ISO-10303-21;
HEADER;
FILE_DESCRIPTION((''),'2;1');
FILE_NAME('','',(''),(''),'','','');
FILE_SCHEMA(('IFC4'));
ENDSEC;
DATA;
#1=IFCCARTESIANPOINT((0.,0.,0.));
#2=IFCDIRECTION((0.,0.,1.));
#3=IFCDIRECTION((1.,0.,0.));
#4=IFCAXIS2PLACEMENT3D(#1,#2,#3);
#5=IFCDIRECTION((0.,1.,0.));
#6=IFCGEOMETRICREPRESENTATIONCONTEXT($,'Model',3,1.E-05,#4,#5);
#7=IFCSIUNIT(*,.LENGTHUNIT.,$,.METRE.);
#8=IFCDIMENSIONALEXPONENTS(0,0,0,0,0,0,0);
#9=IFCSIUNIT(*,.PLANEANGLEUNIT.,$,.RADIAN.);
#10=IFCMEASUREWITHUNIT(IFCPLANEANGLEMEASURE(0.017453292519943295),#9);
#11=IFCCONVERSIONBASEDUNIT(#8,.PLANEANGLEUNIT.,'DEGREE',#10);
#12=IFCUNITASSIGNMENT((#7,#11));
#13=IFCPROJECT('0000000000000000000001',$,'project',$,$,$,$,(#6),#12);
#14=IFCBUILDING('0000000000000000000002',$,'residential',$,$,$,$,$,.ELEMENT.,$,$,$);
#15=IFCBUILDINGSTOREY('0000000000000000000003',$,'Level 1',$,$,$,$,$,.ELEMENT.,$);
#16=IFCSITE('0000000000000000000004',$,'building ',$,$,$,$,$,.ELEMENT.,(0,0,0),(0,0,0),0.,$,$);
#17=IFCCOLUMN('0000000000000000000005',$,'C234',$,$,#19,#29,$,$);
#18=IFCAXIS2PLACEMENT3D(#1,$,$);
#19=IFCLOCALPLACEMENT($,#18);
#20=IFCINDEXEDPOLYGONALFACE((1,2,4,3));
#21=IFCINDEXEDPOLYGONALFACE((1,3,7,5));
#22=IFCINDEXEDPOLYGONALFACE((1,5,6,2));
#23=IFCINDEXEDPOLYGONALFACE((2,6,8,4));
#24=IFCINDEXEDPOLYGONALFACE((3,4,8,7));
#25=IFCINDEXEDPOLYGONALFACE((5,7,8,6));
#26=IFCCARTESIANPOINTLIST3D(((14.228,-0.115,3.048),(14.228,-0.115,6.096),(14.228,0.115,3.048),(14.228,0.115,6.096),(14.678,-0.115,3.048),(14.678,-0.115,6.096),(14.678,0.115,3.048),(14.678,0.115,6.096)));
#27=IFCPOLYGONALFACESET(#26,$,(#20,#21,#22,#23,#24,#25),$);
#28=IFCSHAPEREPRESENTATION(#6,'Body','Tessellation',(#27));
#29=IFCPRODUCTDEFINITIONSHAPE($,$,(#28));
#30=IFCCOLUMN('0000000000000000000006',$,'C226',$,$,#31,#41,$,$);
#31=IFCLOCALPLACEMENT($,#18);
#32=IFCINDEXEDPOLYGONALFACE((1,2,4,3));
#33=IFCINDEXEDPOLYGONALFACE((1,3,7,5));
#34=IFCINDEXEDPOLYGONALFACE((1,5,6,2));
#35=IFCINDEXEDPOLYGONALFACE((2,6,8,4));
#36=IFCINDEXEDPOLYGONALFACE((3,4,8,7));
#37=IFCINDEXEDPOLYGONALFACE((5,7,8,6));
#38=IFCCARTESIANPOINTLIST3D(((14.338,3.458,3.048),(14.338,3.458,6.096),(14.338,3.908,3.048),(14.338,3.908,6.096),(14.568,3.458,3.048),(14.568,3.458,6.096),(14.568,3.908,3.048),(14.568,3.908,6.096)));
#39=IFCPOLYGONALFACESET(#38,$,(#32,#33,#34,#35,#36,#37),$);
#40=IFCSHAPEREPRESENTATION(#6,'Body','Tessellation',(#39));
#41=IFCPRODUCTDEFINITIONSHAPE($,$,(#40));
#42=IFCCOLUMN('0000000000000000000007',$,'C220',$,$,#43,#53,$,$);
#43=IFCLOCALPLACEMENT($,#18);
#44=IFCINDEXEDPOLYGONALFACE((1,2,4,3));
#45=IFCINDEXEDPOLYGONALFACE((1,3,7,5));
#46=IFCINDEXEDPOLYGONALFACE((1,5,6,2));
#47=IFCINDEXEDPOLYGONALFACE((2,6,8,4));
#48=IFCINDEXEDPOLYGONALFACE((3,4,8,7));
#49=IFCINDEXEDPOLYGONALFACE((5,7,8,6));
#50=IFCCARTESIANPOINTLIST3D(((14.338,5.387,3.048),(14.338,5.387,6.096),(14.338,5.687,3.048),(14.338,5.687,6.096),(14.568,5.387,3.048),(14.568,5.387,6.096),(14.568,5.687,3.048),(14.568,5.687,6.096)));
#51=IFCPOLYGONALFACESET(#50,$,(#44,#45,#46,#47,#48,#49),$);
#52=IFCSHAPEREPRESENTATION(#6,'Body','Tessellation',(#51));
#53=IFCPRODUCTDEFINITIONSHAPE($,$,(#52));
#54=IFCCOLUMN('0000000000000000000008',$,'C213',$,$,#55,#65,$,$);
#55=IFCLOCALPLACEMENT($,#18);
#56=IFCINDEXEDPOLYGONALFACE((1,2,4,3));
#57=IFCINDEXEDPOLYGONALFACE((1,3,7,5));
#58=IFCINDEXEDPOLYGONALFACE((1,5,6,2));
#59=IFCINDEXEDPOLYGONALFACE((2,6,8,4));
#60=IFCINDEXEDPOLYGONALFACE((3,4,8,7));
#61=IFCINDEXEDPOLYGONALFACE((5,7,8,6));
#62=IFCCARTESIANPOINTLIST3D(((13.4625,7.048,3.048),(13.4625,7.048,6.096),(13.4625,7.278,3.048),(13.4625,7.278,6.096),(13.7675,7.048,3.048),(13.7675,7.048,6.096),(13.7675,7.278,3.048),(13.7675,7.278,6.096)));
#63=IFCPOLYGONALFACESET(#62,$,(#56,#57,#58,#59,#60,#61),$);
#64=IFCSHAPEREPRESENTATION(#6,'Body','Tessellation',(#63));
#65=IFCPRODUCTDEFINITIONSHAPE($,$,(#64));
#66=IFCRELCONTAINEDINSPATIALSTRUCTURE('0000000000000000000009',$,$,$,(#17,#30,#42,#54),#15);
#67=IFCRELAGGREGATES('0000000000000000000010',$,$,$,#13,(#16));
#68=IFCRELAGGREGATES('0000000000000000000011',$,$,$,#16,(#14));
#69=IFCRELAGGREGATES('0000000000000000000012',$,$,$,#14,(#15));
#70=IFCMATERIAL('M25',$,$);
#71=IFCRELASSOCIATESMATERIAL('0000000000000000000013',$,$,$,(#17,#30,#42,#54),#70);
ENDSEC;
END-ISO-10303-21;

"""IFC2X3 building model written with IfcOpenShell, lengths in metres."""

from ifc_helpers import new_model, entity, si_unit, converted_unit, direction, frame, frame_2d, origin_with_axes, place, context, project, spatial, rectangle, extrude, material, element, save


model = new_model("IFC2X3")

# Units and contexts
model_context = context("Model", 3, precision=1e-05, world=origin_with_axes(), true_north=direction((0.0, 1.0, 0.0)))
ifc_project = project(units=[si_unit("LENGTHUNIT", "METRE"), converted_unit("PLANEANGLEUNIT", "DEGREE", entity("IfcPlaneAngleMeasure", 0.017453292519943295), si_unit("PLANEANGLEUNIT", "RADIAN"), dimensions=[0, 0, 0, 0, 0, 0, 0])], contexts=[model_context])

# Site, building, storey
site = spatial("IfcSite", under=ifc_project, Name="building ", CompositionType="ELEMENT", RefLatitude=(0, 0, 0), RefLongitude=(0, 0, 0), RefElevation=0.0)
building = spatial("IfcBuilding", under=site, Name="residential", CompositionType="ELEMENT")
storey = spatial("IfcBuildingStorey", under=building, Name="Level 1", CompositionType="ELEMENT")

# Columns
ifc_material = material(Name="M25")
placement = place(None, origin_with_axes())
element("IfcColumn", 1, at=placement, inside=storey, material=ifc_material, Name="C234", context=model_context, shape_type="SweptSolid", body=[
    extrude(rectangle(XDim=0.45, YDim=0.23, at=frame_2d((0.0, 0.0), x_axis=(1.0, 0.0, 0.0))), frame((14.453, 0.0, 3.048), z_axis=(0.0, 0.0, 1.0), x_axis=(1.0, 0.0, 0.0)), (0.0, 0.0, 1.0), 3.048),
])
element("IfcColumn", 2, at=placement, inside=storey, material=ifc_material, Name="C226", context=model_context, shape_type="SweptSolid", body=[
    extrude(rectangle(XDim=0.23, YDim=0.45, at=frame_2d((0.0, 0.0), x_axis=(1.0, 0.0, 0.0))), frame((14.453, 3.683, 3.048), z_axis=(0.0, 0.0, 1.0), x_axis=(1.0, 0.0, 0.0)), (0.0, 0.0, 1.0), 3.048),
])
element("IfcColumn", 3, at=placement, inside=storey, material=ifc_material, Name="C220", context=model_context, shape_type="SweptSolid", body=[
    extrude(rectangle(XDim=0.23, YDim=0.3, at=frame_2d((0.0, 0.0), x_axis=(1.0, 0.0, 0.0))), frame((14.453, 5.537, 3.048), z_axis=(0.0, 0.0, 1.0), x_axis=(1.0, 0.0, 0.0)), (0.0, 0.0, 1.0), 3.048),
])
element("IfcColumn", 4, at=placement, inside=storey, material=ifc_material, Name="C213", context=model_context, shape_type="SweptSolid", body=[
    extrude(rectangle(XDim=0.305, YDim=0.23, at=frame_2d((0.0, 0.0), x_axis=(1.0, 0.0, 0.0))), frame((13.615, 7.163, 3.048), z_axis=(0.0, 0.0, 1.0), x_axis=(1.0, 0.0, 0.0)), (0.0, 0.0, 1.0), 3.048),
])

save(model, "model.ifc")
